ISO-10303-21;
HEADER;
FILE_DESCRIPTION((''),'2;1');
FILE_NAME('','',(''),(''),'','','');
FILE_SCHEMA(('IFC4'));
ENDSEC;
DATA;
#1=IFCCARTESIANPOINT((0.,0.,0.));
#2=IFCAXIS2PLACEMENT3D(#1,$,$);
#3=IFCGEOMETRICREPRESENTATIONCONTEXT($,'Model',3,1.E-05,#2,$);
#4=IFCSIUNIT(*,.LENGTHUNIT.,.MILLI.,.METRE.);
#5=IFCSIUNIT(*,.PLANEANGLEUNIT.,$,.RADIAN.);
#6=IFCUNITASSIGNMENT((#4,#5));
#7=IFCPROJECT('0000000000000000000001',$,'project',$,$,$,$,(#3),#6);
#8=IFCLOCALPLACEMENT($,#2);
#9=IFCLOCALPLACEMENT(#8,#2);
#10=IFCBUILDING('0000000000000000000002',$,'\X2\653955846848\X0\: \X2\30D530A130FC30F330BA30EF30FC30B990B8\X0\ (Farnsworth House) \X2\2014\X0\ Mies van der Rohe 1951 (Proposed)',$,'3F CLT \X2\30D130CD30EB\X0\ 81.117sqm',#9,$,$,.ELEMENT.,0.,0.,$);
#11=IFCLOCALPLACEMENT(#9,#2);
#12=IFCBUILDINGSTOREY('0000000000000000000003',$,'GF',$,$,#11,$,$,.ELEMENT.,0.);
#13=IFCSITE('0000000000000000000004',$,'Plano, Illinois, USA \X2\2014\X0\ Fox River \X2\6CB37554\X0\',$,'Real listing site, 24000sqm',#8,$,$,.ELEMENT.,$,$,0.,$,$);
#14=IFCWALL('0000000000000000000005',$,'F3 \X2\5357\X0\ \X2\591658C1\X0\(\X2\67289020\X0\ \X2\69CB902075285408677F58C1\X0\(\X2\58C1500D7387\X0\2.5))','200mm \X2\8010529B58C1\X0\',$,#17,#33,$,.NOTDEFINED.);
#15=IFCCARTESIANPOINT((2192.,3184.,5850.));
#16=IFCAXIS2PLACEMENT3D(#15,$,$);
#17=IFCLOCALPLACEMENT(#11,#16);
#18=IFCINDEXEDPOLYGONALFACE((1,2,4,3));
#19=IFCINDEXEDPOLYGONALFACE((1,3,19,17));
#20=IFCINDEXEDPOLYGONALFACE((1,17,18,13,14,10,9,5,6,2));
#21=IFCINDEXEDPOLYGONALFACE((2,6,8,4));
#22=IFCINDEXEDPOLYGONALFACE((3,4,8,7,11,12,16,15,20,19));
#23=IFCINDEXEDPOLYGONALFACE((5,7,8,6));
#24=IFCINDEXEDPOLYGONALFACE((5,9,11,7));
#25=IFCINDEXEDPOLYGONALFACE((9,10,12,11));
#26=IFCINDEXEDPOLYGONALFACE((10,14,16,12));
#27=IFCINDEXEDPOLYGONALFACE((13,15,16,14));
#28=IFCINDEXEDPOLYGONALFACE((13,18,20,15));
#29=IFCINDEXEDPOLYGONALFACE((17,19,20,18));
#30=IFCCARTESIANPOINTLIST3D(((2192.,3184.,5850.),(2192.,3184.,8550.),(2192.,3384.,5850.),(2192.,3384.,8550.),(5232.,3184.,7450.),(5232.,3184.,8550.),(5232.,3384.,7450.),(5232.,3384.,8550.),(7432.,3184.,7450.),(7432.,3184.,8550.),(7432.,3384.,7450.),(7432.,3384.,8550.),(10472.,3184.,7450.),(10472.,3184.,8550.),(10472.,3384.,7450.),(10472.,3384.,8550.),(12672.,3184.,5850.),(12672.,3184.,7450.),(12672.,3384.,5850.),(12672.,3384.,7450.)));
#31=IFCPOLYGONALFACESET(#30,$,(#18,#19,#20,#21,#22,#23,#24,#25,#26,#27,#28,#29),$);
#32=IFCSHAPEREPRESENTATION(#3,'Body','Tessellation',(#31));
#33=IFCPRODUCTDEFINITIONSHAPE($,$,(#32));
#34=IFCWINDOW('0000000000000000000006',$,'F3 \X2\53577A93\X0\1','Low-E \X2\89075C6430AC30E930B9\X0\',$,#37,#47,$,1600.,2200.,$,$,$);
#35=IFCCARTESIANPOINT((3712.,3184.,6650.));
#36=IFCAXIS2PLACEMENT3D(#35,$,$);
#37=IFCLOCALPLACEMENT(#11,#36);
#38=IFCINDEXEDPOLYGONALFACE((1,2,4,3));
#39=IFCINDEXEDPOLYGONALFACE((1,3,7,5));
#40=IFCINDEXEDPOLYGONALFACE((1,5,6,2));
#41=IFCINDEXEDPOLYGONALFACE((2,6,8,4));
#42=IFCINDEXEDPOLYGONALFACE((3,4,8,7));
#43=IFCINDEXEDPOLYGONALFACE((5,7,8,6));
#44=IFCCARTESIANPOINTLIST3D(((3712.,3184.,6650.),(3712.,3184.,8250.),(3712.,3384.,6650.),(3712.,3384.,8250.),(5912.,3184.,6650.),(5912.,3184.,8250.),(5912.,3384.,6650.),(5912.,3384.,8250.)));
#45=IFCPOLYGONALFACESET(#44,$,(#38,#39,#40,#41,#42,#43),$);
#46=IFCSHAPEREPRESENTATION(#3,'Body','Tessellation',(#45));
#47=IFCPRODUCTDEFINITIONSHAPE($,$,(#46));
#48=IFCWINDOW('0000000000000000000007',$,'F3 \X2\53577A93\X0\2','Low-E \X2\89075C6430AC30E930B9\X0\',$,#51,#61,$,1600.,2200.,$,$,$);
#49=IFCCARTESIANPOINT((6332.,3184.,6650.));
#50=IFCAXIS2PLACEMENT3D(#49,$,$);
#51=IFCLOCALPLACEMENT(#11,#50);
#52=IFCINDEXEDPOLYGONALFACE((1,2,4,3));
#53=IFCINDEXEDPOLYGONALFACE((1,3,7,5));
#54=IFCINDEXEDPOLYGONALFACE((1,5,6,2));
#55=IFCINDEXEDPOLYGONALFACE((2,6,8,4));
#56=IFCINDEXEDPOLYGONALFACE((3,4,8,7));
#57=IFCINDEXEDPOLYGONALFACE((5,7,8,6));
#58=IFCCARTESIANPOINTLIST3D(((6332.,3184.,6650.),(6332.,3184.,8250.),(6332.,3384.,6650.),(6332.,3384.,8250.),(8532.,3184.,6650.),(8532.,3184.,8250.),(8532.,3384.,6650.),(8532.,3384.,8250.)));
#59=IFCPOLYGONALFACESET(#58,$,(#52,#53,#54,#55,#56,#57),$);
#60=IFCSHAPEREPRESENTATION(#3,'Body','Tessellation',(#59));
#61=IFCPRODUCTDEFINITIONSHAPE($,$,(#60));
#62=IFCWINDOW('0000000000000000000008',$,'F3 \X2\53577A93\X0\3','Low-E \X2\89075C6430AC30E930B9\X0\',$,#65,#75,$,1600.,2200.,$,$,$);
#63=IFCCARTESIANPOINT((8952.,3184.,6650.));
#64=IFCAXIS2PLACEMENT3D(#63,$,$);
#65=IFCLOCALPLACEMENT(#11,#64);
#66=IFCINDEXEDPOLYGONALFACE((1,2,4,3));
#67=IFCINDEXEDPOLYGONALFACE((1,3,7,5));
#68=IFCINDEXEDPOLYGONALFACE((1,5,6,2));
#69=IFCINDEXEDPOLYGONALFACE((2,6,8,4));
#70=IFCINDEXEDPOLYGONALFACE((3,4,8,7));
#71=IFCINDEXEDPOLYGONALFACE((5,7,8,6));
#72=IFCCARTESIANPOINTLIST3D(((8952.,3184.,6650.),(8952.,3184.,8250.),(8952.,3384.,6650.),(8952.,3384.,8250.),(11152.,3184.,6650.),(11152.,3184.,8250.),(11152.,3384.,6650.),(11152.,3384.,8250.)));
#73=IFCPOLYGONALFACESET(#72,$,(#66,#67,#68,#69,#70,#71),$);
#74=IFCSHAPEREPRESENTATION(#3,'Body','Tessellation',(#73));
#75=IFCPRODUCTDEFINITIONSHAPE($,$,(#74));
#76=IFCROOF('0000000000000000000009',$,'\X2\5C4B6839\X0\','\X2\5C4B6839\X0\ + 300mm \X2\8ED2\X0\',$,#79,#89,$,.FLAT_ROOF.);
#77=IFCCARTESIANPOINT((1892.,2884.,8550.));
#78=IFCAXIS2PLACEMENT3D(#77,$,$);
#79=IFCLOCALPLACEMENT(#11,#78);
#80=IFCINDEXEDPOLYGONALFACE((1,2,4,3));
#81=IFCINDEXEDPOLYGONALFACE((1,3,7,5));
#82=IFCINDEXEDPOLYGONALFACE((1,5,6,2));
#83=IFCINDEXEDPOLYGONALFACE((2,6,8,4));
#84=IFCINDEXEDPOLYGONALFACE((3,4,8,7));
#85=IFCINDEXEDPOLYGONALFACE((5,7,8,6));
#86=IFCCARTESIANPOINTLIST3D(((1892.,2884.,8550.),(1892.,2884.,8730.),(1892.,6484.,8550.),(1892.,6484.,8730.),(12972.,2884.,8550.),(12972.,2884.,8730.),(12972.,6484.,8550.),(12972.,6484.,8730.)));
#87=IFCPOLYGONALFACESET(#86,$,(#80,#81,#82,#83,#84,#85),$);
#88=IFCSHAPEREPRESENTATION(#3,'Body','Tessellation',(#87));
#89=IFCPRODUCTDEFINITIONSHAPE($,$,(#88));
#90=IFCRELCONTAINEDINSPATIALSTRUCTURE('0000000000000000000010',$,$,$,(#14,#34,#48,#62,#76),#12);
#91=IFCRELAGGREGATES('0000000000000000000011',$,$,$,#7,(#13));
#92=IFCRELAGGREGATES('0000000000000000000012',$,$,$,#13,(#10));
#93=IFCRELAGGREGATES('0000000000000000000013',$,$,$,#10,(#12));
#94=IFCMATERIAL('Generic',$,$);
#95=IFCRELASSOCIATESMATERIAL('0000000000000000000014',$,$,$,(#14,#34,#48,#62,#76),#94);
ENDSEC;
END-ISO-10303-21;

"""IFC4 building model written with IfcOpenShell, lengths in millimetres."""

from ifc_helpers import new_model, si_unit, frame, frame_2d, origin, place, context, project, spatial, rectangle, extrude, material, element, fill, save


model = new_model("IFC4")

# Units and contexts
model_context = context("Model", 3, precision=1e-05, world=origin())
ifc_project = project(units=[si_unit("LENGTHUNIT", "METRE", prefix="MILLI"), si_unit("PLANEANGLEUNIT", "RADIAN")], contexts=[model_context])

# Site, building, storey
site_placement = place(None, origin())
site = spatial("IfcSite", under=ifc_project, at=site_placement, Name="Plano, Illinois, USA — Fox River 河畔", ObjectType="Real listing site, 24000sqm", CompositionType="ELEMENT", RefElevation=0.0)
building_placement = place(site_placement, origin())
building = spatial("IfcBuilding", under=site, at=building_placement, Name="改善案: ファーンズワース邸 (Farnsworth House) — Mies van der Rohe 1951 (Proposed)", ObjectType="3F CLT パネル 81.117sqm", CompositionType="ELEMENT", ElevationOfRefHeight=0.0, ElevationOfTerrain=0.0)
storey_placement = place(building_placement, origin())
storey = spatial("IfcBuildingStorey", under=building, at=storey_placement, Name="GF", CompositionType="ELEMENT", Elevation=0.0)

# Shared definitions
ifc_material = material(Name="Generic")

# Wall, openings, windows
wall_1_placement = place(storey_placement, frame((2192.0, 3184.0, 5850.0)))
wall_1 = element("IfcWall", 1, at=wall_1_placement, inside=storey, material=ifc_material, Name="F3 南 外壁(木造 構造用合板壁(壁倍率2.5))", Description="200mm 耐力壁", PredefinedType="NOTDEFINED", context=model_context, shape_type="SweptSolid", body=[
    extrude(rectangle(XDim=10480.0, YDim=200.0, at=frame_2d((5240.0, 100.0))), frame((2192.0, 3184.0, 5850.0)), (0.0, 0.0, 1.0), 2700.0),
])
opening_1_placement = place(storey_placement, frame((3712.0, 3184.0, 6650.0)))
opening_1 = element("IfcOpeningElement", 2, at=opening_1_placement, cuts=wall_1, PredefinedType="NOTDEFINED", context=model_context, shape_type="SweptSolid", body=[
    extrude(rectangle(XDim=2200.0, YDim=200.0, at=frame_2d((1100.0, 100.0))), frame((3712.0, 3184.0, 6650.0)), (0.0, 0.0, 1.0), 1600.0),
])
opening_2_placement = place(storey_placement, frame((6332.0, 3184.0, 6650.0)))
opening_2 = element("IfcOpeningElement", 3, at=opening_2_placement, cuts=wall_1, PredefinedType="NOTDEFINED", context=model_context, shape_type="SweptSolid", body=[
    extrude(rectangle(XDim=2200.0, YDim=200.0, at=frame_2d((1100.0, 100.0))), frame((6332.0, 3184.0, 6650.0)), (0.0, 0.0, 1.0), 1600.0),
])
opening_3_placement = place(storey_placement, frame((8952.0, 3184.0, 6650.0)))
opening_3 = element("IfcOpeningElement", 4, at=opening_3_placement, cuts=wall_1, PredefinedType="NOTDEFINED", context=model_context, shape_type="SweptSolid", body=[
    extrude(rectangle(XDim=2200.0, YDim=200.0, at=frame_2d((1100.0, 100.0))), frame((8952.0, 3184.0, 6650.0)), (0.0, 0.0, 1.0), 1600.0),
])
window_1_placement = place(storey_placement, frame((3712.0, 3184.0, 6650.0)))
window_1 = element("IfcWindow", 5, at=window_1_placement, inside=storey, material=ifc_material, Name="F3 南窓1", Description="Low-E 複層ガラス", OverallHeight=1600.0, OverallWidth=2200.0, context=model_context, shape_type="SweptSolid", body=[
    extrude(rectangle(XDim=2200.0, YDim=200.0, at=frame_2d((1100.0, 100.0))), frame((3712.0, 3184.0, 6650.0)), (0.0, 0.0, 1.0), 1600.0),
])
fill(opening_1, window_1)
window_2_placement = place(storey_placement, frame((6332.0, 3184.0, 6650.0)))
window_2 = element("IfcWindow", 6, at=window_2_placement, inside=storey, material=ifc_material, Name="F3 南窓2", Description="Low-E 複層ガラス", OverallHeight=1600.0, OverallWidth=2200.0, context=model_context, shape_type="SweptSolid", body=[
    extrude(rectangle(XDim=2200.0, YDim=200.0, at=frame_2d((1100.0, 100.0))), frame((6332.0, 3184.0, 6650.0)), (0.0, 0.0, 1.0), 1600.0),
])
fill(opening_2, window_2)
window_3_placement = place(storey_placement, frame((8952.0, 3184.0, 6650.0)))
window_3 = element("IfcWindow", 7, at=window_3_placement, inside=storey, material=ifc_material, Name="F3 南窓3", Description="Low-E 複層ガラス", OverallHeight=1600.0, OverallWidth=2200.0, context=model_context, shape_type="SweptSolid", body=[
    extrude(rectangle(XDim=2200.0, YDim=200.0, at=frame_2d((1100.0, 100.0))), frame((8952.0, 3184.0, 6650.0)), (0.0, 0.0, 1.0), 1600.0),
])
fill(opening_3, window_3)

# Roof
roof_placement = place(storey_placement, frame((1892.0, 2884.0, 8550.0)))
element("IfcRoof", 8, at=roof_placement, inside=storey, material=ifc_material, Name="屋根", Description="屋根 + 300mm 軒", PredefinedType="FLAT_ROOF", context=model_context, shape_type="SweptSolid", body=[
    extrude(rectangle(XDim=11080.0, YDim=3600.0, at=frame_2d((5540.0, 1800.0))), frame((1892.0, 2884.0, 8550.0)), (0.0, 0.0, 1.0), 180.0),
])

save(model, "model.ifc")
